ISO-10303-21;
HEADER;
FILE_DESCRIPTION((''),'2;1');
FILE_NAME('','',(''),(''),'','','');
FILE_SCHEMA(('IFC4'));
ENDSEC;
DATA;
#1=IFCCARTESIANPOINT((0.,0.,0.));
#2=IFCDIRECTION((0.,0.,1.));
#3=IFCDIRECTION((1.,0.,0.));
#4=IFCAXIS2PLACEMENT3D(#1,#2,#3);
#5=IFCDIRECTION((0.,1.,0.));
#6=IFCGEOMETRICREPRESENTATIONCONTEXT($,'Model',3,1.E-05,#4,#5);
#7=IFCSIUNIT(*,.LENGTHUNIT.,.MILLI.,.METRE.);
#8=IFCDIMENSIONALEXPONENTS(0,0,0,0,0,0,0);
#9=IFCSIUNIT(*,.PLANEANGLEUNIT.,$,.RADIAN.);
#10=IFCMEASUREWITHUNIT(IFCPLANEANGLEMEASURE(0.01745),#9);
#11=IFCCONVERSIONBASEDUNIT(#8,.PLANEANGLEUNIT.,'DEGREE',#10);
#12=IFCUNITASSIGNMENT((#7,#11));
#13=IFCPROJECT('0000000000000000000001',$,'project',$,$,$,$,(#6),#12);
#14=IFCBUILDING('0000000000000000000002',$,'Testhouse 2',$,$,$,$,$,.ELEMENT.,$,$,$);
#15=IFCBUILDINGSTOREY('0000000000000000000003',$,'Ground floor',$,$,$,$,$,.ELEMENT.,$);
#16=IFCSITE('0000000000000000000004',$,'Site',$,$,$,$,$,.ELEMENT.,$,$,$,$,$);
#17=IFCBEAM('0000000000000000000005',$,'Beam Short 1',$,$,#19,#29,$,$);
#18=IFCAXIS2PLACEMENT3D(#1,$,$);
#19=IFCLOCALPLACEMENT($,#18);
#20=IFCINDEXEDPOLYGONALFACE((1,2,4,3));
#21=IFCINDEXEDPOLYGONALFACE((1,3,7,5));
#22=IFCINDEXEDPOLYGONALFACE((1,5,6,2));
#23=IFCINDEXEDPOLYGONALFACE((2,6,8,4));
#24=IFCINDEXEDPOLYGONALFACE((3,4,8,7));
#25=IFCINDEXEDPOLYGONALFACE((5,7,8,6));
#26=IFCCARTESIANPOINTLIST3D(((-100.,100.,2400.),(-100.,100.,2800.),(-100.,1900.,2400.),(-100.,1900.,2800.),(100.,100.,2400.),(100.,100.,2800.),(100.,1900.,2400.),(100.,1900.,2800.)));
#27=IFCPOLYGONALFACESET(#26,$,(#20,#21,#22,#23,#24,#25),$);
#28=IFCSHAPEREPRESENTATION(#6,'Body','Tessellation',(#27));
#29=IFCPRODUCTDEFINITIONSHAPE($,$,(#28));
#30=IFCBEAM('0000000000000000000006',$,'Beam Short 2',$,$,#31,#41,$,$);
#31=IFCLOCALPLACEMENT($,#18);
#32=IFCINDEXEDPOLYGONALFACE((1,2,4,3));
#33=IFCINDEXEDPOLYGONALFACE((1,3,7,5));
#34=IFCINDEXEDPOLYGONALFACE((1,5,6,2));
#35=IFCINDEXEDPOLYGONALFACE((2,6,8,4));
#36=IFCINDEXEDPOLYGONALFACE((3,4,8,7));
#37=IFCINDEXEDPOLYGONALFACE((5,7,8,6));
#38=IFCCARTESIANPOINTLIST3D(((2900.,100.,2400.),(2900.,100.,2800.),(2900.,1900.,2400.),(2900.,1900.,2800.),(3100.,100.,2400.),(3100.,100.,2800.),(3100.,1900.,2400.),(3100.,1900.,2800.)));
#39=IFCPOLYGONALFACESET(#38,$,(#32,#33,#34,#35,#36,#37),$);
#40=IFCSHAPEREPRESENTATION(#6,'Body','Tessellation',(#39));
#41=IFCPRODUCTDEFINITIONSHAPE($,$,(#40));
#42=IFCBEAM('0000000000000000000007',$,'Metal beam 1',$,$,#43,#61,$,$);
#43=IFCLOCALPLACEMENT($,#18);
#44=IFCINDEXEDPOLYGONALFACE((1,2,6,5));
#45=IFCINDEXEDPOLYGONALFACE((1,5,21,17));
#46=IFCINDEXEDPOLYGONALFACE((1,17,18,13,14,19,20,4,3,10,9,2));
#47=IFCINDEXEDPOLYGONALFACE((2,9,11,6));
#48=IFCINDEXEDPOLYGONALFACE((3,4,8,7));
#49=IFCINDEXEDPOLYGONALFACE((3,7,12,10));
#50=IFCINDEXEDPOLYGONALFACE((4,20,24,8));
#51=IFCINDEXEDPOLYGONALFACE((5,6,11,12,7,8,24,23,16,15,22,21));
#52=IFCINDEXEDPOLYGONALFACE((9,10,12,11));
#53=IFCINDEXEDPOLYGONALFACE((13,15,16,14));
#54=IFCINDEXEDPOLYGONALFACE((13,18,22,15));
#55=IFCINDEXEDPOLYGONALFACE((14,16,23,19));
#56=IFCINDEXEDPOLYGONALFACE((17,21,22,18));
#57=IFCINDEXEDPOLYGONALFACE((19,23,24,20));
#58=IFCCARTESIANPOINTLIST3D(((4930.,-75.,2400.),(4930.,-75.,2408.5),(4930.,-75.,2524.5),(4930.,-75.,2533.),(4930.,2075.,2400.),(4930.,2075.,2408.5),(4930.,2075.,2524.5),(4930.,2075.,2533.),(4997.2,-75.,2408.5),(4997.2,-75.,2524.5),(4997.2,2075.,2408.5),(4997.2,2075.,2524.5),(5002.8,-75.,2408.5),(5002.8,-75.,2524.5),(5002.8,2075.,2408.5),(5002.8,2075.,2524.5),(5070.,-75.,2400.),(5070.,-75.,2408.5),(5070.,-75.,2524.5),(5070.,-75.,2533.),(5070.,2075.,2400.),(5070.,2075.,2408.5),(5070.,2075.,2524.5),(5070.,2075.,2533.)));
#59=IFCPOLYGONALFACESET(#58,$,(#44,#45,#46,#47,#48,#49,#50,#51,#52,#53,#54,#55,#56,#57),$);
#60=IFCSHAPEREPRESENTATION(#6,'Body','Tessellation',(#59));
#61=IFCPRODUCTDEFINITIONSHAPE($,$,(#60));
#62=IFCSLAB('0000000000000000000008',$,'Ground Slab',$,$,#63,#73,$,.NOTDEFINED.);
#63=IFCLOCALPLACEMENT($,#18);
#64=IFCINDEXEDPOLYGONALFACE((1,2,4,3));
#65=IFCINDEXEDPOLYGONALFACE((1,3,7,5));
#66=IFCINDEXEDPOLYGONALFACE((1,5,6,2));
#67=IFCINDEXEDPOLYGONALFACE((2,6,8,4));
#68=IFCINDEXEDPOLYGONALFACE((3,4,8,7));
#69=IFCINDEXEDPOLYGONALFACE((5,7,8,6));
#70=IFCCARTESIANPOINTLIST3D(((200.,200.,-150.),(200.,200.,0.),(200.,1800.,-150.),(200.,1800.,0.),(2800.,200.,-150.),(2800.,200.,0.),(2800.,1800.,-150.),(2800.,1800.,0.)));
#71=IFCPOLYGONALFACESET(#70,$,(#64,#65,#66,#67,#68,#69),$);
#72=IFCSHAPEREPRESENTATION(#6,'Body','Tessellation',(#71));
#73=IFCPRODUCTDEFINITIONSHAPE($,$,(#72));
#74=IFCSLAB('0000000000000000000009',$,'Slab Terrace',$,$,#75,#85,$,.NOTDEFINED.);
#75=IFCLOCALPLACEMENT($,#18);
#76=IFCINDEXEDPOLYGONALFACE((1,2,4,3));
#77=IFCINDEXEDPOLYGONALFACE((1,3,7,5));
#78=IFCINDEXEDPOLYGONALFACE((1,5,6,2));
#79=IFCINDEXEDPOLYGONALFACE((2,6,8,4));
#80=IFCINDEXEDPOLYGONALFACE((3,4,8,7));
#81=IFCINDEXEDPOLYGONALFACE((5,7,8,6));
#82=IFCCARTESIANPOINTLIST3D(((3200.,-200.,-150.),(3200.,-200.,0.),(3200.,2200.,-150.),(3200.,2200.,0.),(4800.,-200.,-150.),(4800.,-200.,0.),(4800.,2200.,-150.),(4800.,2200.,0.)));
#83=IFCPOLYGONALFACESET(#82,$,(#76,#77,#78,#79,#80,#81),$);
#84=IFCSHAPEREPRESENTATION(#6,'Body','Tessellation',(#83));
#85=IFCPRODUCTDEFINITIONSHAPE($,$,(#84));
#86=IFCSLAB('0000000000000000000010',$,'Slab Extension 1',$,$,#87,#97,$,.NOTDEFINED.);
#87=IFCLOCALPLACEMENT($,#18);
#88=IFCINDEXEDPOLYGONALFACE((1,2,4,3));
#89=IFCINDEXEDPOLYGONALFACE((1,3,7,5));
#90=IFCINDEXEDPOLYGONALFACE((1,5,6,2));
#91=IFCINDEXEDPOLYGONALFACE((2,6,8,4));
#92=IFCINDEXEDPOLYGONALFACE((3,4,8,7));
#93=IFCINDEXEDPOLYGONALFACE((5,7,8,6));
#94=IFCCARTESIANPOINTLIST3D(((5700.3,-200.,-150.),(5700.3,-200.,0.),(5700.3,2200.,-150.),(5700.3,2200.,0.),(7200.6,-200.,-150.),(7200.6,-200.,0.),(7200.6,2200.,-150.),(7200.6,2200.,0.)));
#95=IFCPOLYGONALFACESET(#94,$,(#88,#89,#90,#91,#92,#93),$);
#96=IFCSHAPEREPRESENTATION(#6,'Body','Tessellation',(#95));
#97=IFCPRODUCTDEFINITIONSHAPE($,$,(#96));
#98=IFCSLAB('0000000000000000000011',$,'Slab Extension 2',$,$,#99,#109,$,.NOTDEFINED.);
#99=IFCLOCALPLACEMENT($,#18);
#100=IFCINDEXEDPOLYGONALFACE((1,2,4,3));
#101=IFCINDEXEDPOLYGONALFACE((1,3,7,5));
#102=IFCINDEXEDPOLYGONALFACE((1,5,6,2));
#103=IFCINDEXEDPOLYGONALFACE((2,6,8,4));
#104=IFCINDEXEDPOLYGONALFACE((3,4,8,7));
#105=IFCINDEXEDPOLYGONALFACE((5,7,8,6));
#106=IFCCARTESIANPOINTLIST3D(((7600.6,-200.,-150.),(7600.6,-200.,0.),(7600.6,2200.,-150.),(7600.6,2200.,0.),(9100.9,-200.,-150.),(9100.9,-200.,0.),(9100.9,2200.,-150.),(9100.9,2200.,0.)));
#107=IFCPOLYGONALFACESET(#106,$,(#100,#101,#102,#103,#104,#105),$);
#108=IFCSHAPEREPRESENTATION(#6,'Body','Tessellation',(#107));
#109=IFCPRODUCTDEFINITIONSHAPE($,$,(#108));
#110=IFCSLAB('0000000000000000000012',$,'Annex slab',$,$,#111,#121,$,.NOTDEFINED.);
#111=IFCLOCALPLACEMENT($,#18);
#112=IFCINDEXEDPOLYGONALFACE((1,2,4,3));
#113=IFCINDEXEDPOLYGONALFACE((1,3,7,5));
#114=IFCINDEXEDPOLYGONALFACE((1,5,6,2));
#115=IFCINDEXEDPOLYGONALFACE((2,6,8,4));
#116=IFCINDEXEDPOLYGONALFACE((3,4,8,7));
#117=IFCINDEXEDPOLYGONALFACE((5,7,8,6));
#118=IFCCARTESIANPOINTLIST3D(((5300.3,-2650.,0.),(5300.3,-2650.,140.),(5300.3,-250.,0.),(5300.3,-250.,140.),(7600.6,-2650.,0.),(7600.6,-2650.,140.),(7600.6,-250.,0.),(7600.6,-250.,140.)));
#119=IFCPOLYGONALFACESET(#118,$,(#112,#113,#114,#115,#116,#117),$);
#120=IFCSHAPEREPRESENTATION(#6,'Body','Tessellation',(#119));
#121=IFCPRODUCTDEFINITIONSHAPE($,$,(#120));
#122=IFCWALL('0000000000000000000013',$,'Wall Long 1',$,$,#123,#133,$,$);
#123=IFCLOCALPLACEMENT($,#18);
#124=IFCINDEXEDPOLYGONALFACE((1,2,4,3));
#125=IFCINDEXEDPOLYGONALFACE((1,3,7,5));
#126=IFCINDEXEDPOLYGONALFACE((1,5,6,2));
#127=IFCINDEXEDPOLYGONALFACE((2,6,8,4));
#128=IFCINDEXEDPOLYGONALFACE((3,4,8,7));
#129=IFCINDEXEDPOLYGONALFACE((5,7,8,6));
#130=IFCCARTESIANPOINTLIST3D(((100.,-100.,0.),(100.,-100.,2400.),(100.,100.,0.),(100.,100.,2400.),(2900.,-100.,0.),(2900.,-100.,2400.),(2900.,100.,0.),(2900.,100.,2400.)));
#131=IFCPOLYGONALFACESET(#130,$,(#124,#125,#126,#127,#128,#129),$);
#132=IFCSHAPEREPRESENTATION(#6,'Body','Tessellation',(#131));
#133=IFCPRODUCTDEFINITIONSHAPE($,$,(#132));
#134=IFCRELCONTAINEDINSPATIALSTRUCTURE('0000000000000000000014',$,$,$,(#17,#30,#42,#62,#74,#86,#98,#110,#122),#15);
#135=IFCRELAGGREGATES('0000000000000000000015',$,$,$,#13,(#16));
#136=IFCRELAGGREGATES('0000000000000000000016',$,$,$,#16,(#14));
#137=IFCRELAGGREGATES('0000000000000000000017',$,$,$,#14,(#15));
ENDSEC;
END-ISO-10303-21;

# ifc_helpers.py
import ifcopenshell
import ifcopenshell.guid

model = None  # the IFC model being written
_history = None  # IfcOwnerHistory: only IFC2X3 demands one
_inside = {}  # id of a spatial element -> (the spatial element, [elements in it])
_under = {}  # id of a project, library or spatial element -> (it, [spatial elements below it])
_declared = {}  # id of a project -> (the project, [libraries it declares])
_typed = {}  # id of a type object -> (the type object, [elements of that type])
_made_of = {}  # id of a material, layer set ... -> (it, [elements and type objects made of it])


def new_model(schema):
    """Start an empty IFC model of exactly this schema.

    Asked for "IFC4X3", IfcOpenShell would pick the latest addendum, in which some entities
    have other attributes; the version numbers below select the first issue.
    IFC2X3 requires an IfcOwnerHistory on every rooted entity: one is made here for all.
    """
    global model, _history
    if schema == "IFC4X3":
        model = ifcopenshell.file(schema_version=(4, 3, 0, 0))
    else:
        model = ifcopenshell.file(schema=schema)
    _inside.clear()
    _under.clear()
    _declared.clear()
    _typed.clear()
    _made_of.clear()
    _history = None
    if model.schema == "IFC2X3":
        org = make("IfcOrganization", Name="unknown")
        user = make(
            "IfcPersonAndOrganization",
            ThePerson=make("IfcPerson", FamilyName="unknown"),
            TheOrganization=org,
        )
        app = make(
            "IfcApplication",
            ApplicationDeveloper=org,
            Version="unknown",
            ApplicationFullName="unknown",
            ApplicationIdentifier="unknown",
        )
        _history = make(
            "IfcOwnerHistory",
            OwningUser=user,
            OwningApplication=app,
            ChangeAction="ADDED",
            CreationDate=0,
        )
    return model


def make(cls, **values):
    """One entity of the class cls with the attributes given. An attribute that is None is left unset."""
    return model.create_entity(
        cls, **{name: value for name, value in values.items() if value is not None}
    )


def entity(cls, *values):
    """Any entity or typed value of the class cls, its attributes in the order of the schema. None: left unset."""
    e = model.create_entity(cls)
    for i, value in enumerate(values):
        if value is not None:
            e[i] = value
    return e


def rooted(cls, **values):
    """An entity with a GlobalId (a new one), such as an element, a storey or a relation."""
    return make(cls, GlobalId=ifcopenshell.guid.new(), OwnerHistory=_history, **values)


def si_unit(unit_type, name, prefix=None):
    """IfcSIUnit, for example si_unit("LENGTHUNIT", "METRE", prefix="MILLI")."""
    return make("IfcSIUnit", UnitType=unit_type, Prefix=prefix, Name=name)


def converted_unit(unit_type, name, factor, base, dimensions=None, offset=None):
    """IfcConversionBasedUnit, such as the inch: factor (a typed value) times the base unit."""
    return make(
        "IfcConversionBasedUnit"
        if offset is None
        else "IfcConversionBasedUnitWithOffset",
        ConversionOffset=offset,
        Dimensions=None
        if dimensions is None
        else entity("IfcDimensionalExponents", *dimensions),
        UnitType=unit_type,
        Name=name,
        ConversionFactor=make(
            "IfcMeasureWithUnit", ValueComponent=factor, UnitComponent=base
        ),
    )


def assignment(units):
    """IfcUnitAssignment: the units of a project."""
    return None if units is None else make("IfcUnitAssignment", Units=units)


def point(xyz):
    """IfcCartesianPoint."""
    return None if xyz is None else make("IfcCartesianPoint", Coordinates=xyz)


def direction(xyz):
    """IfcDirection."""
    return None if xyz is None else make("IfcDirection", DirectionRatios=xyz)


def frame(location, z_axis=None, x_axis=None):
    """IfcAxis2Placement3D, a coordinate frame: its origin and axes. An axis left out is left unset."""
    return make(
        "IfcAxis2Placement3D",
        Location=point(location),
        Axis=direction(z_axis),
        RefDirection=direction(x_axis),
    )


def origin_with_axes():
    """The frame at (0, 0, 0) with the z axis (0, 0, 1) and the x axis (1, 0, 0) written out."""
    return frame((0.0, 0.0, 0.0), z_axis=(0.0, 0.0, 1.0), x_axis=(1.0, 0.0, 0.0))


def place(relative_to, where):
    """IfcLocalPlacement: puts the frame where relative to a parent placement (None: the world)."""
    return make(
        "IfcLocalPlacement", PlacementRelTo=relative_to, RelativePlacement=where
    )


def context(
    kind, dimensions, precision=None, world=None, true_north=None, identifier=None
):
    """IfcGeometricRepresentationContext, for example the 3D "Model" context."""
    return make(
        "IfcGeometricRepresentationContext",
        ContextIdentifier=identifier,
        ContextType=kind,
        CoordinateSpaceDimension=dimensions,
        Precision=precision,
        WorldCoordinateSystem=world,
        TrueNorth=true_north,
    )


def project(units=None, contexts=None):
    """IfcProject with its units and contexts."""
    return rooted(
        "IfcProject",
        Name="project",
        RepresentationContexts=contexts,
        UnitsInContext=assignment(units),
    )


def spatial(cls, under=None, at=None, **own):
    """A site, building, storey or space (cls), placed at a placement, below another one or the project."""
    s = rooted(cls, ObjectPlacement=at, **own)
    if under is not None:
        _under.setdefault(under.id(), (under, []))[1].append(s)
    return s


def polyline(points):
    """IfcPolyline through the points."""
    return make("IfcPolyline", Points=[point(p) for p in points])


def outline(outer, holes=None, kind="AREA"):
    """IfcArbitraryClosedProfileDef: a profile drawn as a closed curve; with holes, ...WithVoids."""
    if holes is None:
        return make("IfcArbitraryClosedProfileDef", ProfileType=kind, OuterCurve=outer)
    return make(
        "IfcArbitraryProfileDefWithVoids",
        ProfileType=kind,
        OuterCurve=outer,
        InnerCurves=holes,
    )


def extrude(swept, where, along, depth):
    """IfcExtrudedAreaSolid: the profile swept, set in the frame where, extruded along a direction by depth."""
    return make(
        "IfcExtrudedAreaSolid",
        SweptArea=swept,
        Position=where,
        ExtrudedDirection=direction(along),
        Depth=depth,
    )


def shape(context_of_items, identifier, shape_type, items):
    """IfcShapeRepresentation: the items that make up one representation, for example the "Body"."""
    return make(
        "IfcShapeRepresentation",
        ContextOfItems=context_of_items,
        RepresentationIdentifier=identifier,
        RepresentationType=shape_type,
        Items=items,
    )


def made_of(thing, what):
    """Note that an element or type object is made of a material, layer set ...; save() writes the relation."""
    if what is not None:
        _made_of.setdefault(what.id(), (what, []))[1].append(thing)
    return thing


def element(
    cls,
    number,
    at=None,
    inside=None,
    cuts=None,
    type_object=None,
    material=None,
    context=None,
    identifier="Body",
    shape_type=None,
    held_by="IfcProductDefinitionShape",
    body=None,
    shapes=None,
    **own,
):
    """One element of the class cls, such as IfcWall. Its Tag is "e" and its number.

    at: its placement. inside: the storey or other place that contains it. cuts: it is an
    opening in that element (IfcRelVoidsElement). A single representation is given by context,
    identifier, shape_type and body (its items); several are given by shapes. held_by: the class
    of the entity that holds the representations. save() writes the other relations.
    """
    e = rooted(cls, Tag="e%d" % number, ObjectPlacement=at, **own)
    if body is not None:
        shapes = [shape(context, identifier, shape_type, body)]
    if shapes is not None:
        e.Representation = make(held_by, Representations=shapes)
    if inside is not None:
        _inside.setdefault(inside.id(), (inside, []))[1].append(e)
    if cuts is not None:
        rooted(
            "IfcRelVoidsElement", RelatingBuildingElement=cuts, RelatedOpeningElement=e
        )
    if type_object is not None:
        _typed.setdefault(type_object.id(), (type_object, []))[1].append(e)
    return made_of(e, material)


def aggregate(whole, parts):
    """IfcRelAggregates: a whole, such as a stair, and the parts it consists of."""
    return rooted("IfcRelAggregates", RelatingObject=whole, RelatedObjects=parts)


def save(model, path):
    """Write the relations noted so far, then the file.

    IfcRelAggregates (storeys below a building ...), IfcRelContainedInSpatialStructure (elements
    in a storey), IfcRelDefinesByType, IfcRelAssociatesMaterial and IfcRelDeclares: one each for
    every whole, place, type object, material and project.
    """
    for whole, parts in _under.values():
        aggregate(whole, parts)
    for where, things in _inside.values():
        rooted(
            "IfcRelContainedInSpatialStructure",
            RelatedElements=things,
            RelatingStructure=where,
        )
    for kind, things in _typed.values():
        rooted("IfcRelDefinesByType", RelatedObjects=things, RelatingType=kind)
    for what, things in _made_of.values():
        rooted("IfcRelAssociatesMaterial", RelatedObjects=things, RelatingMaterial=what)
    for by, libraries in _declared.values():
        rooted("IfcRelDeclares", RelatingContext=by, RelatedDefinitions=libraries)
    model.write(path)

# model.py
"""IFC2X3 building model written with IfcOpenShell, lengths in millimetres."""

from ifc_helpers import new_model, entity, si_unit, converted_unit, direction, frame, origin_with_axes, place, context, project, spatial, polyline, outline, extrude, element, save


model = new_model("IFC2X3")

# Units and contexts
model_context = context("Model", 3, precision=1e-05, world=origin_with_axes(), true_north=direction((0.0, 1.0, 0.0)))
ifc_project = project(units=[si_unit("LENGTHUNIT", "METRE", prefix="MILLI"), converted_unit("PLANEANGLEUNIT", "DEGREE", entity("IfcPlaneAngleMeasure", 0.01745), si_unit("PLANEANGLEUNIT", "RADIAN"), dimensions=[0, 0, 0, 0, 0, 0, 0])], contexts=[model_context])

# Site, building, storey
site = spatial("IfcSite", under=ifc_project, Name="Site", CompositionType="ELEMENT")
building = spatial("IfcBuilding", under=site, Name="Testhouse 2", CompositionType="ELEMENT")
storey = spatial("IfcBuildingStorey", under=building, Name="Ground floor", CompositionType="ELEMENT")

# Beams
beam_1_placement = place(None, origin_with_axes())
element("IfcBeam", 1, at=beam_1_placement, inside=storey, Name="Beam Short 1", context=model_context, shape_type="SweptSolid", body=[
    extrude(outline(polyline([(-200.0, -100.0), (200.0, -100.0), (200.0, 100.0), (-200.0, 100.0), (-200.0, -100.0)])), frame((0.0, 100.0, 2600.0), z_axis=(0.0, 1.0, 0.0), x_axis=(0.0, 0.0, -1.0)), (0.0, 0.0, 1.0), 1800.0),
])
beam_2_placement = place(None, origin_with_axes())
element("IfcBeam", 2, at=beam_2_placement, inside=storey, Name="Beam Short 2", context=model_context, shape_type="SweptSolid", body=[
    extrude(outline(polyline([(-200.0, -100.0), (200.0, -100.0), (200.0, 100.0), (-200.0, 100.0), (-200.0, -100.0)])), frame((3000.0, 100.0, 2600.0), z_axis=(0.0, 1.0, 0.0), x_axis=(0.0, 0.0, -1.0)), (0.0, 0.0, 1.0), 1800.0),
])
beam_3_placement = place(None, origin_with_axes())
element("IfcBeam", 3, at=beam_3_placement, inside=storey, Name="Metal beam 1", context=model_context, shape_type="SweptSolid", body=[
    extrude(outline(polyline([(-70.0, -66.5), (70.0, -66.5), (70.0, -58.0), (2.8, -58.0), (2.8, 58.0), (70.0, 58.0), (70.0, 66.5), (-70.0, 66.5), (-70.0, 58.0), (-2.8, 58.0), (-2.8, -58.0), (-70.0, -58.0), (-70.0, -66.5)])), frame((5000.0, 2075.0, 2466.5), z_axis=(0.0, -1.0, 0.0), x_axis=(1.0, 0.0, 0.0)), (0.0, 0.0, 1.0), 2150.0),
])

# Slabs
slab_1_placement = place(None, origin_with_axes())
element("IfcSlab", 4, at=slab_1_placement, inside=storey, Name="Ground Slab", PredefinedType="NOTDEFINED", context=model_context, shape_type="SweptSolid", body=[
    extrude(outline(polyline([(0.0, 0.0), (2600.0, 0.0), (2600.0, -1600.0), (0.0, -1600.0), (0.0, 0.0)])), frame((200.0, 1800.0, -150.0), z_axis=(0.0, 0.0, 1.0), x_axis=(1.0, 0.0, 0.0)), (0.0, 0.0, 1.0), 150.0),
])
slab_2_placement = place(None, origin_with_axes())
element("IfcSlab", 5, at=slab_2_placement, inside=storey, Name="Slab Terrace", PredefinedType="NOTDEFINED", context=model_context, shape_type="SweptSolid", body=[
    extrude(outline(polyline([(0.0, 0.0), (-1600.0, 0.0), (-1600.0, 2400.0), (0.0, 2400.0), (0.0, 0.0)])), frame((4800.0, -200.0, -150.0), z_axis=(0.0, 0.0, 1.0), x_axis=(1.0, 0.0, 0.0)), (0.0, 0.0, 1.0), 150.0),
])
slab_3_placement = place(None, origin_with_axes())
element("IfcSlab", 6, at=slab_3_placement, inside=storey, Name="Slab Extension 1", PredefinedType="NOTDEFINED", context=model_context, shape_type="SweptSolid", body=[
    extrude(outline(polyline([(0.0, 0.0), (1500.3, 0.0), (1500.3, -2400.0), (0.0, -2400.0), (0.0, 0.0)])), frame((5700.3, 2200.0, -150.0), z_axis=(0.0, 0.0, 1.0), x_axis=(1.0, 0.0, 0.0)), (0.0, 0.0, 1.0), 150.0),
])
slab_4_placement = place(None, origin_with_axes())
element("IfcSlab", 7, at=slab_4_placement, inside=storey, Name="Slab Extension 2", PredefinedType="NOTDEFINED", context=model_context, shape_type="SweptSolid", body=[
    extrude(outline(polyline([(0.0, 0.0), (1500.3, 0.0), (1500.3, -2400.0), (0.0, -2400.0), (0.0, 0.0)])), frame((7600.6, 2200.0, -150.0), z_axis=(0.0, 0.0, 1.0), x_axis=(1.0, 0.0, 0.0)), (0.0, 0.0, 1.0), 150.0),
])
slab_5_placement = place(None, origin_with_axes())
element("IfcSlab", 8, at=slab_5_placement, inside=storey, Name="Annex slab", PredefinedType="NOTDEFINED", context=model_context, shape_type="SweptSolid", body=[
    extrude(outline(polyline([(0.0, 0.0), (2300.3, 0.0), (2300.3, -2400.0), (0.0, -2400.0), (0.0, 0.0)])), frame((5300.3, -250.0, 0.0), z_axis=(0.0, 0.0, 1.0), x_axis=(1.0, 0.0, 0.0)), (0.0, 0.0, 1.0), 140.0),
])

# Wall
wall_1_placement = place(None, origin_with_axes())
element("IfcWall", 9, at=wall_1_placement, inside=storey, Name="Wall Long 1", context=model_context, shape_type="SweptSolid", body=[
    extrude(outline(polyline([(100.0, -100.0), (2900.0, -100.0), (2900.0, 100.0), (100.0, 100.0), (100.0, -100.0)])), origin_with_axes(), (0.0, 0.0, 1.0), 2400.0),
])

save(model, "model.ifc")
